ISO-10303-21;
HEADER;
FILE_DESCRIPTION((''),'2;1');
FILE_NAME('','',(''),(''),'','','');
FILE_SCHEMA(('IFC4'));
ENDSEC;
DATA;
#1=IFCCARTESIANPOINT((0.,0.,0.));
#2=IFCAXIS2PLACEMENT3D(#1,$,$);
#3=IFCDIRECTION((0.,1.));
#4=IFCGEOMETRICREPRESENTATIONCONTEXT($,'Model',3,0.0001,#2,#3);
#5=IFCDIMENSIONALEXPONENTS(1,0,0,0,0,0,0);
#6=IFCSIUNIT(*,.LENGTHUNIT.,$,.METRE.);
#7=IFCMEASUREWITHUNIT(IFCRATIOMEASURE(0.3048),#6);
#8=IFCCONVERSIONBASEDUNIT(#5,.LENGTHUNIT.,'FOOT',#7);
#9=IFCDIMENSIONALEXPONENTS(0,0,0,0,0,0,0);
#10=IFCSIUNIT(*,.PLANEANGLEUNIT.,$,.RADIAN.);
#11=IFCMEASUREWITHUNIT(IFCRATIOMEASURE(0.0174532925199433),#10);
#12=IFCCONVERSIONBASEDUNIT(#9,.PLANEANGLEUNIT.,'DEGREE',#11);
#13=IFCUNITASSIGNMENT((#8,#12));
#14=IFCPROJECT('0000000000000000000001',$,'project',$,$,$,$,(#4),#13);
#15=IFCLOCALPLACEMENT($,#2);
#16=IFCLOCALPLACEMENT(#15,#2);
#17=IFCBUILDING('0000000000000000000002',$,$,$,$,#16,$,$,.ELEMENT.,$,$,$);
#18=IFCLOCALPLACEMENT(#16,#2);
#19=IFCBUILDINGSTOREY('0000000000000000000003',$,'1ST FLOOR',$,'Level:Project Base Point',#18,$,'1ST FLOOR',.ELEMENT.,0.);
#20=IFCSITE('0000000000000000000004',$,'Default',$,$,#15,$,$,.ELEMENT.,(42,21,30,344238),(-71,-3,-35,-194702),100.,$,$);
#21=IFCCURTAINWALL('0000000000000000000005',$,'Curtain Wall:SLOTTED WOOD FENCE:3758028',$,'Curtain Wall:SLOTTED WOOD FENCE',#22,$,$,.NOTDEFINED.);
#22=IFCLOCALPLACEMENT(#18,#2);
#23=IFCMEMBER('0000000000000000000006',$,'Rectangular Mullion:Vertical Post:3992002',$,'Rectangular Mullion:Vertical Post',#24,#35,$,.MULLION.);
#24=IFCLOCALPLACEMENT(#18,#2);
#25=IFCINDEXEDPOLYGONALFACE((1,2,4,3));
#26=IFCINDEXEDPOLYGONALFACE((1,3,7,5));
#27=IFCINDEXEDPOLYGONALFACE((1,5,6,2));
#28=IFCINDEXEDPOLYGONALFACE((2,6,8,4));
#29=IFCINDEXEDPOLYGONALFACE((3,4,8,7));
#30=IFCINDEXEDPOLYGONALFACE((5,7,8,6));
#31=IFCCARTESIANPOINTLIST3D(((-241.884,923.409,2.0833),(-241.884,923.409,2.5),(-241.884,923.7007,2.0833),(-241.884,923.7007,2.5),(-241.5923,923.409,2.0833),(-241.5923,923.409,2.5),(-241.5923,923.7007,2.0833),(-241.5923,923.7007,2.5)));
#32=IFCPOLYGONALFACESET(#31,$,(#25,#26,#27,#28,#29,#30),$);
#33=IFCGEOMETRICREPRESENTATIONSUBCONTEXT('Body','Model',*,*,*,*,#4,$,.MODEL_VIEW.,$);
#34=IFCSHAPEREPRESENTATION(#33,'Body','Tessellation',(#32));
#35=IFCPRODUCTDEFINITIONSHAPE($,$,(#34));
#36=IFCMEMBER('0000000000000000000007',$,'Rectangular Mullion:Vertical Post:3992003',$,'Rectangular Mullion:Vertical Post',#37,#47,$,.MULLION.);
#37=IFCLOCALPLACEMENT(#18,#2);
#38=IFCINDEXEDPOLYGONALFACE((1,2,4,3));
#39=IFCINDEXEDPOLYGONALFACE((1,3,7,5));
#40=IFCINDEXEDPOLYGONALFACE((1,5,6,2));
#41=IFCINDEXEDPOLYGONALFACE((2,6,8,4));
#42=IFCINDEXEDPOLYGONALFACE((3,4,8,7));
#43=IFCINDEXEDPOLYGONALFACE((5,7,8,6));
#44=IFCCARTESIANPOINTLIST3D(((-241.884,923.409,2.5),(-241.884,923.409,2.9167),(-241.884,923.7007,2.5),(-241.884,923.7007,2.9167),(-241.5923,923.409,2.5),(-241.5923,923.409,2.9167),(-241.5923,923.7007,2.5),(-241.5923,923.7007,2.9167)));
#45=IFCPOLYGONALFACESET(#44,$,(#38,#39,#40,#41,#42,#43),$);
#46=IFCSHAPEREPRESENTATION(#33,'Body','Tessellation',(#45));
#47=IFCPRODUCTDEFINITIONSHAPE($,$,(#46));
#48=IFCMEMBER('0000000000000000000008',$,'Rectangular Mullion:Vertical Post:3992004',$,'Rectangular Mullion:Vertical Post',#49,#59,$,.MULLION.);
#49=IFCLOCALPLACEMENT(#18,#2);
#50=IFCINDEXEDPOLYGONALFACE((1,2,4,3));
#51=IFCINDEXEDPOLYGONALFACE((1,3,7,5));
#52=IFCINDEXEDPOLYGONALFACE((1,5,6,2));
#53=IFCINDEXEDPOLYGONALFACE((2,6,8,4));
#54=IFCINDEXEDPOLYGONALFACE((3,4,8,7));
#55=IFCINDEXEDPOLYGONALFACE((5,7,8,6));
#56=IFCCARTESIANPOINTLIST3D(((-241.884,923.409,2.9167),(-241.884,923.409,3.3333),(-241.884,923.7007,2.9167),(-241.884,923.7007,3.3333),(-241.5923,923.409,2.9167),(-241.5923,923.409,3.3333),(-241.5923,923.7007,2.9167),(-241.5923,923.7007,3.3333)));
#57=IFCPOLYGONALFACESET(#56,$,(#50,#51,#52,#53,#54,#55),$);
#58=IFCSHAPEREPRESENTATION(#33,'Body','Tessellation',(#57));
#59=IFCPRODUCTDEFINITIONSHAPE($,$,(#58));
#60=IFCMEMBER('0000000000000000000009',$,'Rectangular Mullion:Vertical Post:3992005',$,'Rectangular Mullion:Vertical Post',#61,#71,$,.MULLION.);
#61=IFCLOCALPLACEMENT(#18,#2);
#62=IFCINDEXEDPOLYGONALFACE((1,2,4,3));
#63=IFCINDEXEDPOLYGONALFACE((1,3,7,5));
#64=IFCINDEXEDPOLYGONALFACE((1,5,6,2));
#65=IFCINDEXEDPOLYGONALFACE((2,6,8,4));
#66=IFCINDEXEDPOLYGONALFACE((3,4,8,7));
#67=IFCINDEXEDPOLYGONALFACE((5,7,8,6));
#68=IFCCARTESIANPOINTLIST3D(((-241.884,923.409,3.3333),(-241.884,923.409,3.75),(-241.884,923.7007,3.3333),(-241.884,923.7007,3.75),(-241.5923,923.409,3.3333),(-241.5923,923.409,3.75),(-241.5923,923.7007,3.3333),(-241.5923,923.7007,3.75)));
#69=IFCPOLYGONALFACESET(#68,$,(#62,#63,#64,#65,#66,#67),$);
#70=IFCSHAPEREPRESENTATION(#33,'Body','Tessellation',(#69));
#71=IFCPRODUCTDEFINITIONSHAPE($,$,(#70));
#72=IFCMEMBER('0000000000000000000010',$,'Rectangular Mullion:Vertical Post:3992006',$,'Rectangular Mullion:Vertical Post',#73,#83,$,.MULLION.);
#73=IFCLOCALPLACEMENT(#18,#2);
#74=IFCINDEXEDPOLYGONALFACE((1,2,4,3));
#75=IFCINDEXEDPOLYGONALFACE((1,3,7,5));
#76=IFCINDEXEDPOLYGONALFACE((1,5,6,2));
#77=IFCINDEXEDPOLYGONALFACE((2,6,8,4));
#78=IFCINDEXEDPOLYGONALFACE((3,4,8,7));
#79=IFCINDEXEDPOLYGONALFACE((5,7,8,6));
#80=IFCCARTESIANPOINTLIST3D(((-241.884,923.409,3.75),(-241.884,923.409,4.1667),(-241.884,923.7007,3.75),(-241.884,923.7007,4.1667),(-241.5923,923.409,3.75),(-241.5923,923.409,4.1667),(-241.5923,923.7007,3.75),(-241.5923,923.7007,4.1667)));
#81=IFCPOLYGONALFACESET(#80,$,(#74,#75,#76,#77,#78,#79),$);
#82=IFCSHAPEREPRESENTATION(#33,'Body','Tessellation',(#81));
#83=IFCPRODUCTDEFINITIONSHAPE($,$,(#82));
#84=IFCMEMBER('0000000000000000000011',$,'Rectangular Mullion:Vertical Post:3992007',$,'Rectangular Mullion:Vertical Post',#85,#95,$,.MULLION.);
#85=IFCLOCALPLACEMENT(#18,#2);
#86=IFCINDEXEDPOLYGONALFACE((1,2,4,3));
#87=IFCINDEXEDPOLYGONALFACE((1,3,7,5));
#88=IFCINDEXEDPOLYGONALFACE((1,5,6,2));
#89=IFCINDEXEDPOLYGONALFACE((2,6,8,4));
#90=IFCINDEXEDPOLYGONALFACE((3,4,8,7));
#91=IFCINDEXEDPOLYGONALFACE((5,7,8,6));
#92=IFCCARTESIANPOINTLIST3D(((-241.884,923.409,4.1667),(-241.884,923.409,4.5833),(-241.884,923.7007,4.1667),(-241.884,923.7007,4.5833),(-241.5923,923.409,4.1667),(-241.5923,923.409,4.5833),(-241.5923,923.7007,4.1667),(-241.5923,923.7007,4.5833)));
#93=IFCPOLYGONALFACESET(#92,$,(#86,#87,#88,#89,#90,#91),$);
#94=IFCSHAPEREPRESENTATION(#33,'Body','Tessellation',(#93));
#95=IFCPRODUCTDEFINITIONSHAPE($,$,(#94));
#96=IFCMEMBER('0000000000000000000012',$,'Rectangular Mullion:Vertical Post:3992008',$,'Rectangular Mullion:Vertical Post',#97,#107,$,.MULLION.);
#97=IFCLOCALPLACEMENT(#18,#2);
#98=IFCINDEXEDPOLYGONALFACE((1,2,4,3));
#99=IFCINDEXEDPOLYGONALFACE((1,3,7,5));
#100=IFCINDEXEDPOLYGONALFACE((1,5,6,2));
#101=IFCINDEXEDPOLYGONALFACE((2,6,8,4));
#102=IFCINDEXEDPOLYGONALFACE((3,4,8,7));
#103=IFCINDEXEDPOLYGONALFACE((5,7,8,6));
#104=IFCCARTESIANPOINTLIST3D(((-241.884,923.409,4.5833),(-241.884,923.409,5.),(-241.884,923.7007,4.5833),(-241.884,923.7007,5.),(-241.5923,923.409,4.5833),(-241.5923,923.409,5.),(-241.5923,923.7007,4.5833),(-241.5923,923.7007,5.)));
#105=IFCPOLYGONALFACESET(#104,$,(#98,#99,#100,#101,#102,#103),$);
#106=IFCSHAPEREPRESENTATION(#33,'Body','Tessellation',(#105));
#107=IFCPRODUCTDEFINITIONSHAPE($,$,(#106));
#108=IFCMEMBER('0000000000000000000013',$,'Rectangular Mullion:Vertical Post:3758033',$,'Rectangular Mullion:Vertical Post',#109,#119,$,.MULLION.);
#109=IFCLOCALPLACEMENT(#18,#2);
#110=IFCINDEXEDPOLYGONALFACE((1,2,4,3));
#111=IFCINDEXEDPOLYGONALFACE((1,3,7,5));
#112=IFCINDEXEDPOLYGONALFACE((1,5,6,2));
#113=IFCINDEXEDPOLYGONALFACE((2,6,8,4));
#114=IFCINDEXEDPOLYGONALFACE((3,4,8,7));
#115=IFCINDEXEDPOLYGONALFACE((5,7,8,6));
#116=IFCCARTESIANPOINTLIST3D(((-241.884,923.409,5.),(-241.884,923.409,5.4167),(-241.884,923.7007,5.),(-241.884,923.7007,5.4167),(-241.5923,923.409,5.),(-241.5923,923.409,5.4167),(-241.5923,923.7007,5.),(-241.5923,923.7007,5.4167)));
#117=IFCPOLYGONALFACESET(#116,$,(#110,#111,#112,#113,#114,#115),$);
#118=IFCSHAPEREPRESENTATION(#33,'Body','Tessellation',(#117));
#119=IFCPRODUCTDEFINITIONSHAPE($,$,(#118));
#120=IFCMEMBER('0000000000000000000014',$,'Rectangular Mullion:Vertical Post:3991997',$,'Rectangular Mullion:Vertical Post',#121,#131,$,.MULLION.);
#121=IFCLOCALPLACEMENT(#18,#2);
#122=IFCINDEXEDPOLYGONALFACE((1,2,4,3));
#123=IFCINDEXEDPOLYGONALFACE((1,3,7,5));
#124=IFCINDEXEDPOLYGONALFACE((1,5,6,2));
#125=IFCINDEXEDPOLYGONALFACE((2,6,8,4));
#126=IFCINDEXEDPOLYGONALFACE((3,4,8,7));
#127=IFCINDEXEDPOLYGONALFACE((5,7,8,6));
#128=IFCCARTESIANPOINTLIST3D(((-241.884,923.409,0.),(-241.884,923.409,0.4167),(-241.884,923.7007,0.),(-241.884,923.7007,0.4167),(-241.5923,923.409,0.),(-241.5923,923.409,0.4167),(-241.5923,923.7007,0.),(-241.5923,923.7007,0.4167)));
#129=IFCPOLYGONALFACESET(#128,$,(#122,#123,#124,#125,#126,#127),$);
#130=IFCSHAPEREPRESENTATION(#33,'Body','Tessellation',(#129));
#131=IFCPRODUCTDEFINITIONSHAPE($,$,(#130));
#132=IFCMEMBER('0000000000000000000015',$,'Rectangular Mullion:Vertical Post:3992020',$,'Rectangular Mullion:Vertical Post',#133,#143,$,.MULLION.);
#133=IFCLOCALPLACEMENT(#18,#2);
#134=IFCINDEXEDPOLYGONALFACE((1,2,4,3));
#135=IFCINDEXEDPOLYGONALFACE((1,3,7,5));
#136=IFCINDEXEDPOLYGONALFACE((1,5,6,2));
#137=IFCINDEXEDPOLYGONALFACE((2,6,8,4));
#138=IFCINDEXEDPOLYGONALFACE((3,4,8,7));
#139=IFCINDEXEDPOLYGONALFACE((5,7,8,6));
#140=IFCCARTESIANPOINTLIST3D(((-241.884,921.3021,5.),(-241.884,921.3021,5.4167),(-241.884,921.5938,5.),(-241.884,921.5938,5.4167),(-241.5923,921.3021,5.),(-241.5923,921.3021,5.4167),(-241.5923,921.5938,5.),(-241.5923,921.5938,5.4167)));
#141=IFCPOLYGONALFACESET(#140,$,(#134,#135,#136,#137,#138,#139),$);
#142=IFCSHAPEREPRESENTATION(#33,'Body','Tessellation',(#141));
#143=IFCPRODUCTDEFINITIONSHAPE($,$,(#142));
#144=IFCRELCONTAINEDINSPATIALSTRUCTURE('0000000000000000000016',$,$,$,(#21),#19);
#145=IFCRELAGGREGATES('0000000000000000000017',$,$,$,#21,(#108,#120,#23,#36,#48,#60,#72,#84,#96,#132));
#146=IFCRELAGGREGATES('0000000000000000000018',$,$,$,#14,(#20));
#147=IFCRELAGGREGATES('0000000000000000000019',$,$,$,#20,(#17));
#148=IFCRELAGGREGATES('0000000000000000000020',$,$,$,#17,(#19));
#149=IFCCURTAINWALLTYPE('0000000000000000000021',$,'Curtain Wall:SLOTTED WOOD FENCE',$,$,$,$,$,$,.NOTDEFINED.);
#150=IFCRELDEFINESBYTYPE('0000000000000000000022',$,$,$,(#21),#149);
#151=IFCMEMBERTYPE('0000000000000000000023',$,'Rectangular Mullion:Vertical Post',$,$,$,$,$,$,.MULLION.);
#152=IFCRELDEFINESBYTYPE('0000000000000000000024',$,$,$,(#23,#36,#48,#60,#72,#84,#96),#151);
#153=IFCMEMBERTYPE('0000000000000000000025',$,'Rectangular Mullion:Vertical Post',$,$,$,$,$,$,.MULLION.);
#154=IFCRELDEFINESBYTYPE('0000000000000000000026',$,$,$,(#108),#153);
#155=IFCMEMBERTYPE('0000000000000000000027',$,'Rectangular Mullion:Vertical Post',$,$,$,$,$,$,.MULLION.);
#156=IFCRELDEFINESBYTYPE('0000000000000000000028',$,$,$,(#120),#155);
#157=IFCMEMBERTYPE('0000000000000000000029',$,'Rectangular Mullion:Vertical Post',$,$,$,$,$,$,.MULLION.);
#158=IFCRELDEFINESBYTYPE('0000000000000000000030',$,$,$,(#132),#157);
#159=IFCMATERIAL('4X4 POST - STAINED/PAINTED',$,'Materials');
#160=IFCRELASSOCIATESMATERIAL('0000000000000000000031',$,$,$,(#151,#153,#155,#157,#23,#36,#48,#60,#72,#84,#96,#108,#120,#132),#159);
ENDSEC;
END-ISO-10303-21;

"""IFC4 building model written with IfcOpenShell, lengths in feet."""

from ifc_helpers import new_model, entity, si_unit, converted_unit, direction, frame, origin, origin_2d_with_axis, place, context, subcontext, project, spatial, rectangle, extrude, source, transform, mapped, material, material_profile, profile_set, profile_usage, type_object, type_shapes, element, aggregate, save


model = new_model("IFC4")

# Units and contexts
model_context = context("Model", 3, precision=0.0001, world=origin(), true_north=direction((0.0, 1.0)))
body_context = subcontext(model_context, "Body", "Model", "MODEL_VIEW")
ifc_project = project(units=[converted_unit("LENGTHUNIT", "FOOT", entity("IfcRatioMeasure", 0.3048), si_unit("LENGTHUNIT", "METRE"), dimensions=[1, 0, 0, 0, 0, 0, 0]), converted_unit("PLANEANGLEUNIT", "DEGREE", entity("IfcRatioMeasure", 0.0174532925199433), si_unit("PLANEANGLEUNIT", "RADIAN"), dimensions=[0, 0, 0, 0, 0, 0, 0])], contexts=[model_context])

# Site, building, storey
site_placement = place(None, origin())
site = spatial("IfcSite", under=ifc_project, at=site_placement, Name="Default", CompositionType="ELEMENT", RefLatitude=(42, 21, 30, 344238), RefLongitude=(-71, -3, -35, -194702), RefElevation=100.0)
building_placement = place(site_placement, origin())
building = spatial("IfcBuilding", under=site, at=building_placement, CompositionType="ELEMENT")
storey_placement = place(building_placement, origin())
storey = spatial("IfcBuildingStorey", under=building, at=storey_placement, Name="1ST FLOOR", ObjectType="Level:Project Base Point", LongName="1ST FLOOR", CompositionType="ELEMENT", Elevation=0.0)

# Curtain wall, members
curtain_wall_type = type_object("IfcCurtainWallType", Name="Curtain Wall:SLOTTED WOOD FENCE", PredefinedType="NOTDEFINED")
curtain_wall_placement = place(storey_placement, origin())
curtain_wall = element("IfcCurtainWall", 1, at=curtain_wall_placement, inside=storey, type_object=curtain_wall_type, Name="Curtain Wall:SLOTTED WOOD FENCE:3758028", ObjectType="Curtain Wall:SLOTTED WOOD FENCE", PredefinedType="NOTDEFINED")
ifc_material = material(Name="4X4 POST - STAINED/PAINTED", Category="Materials")
ifc_material_profile = material_profile(ifc_material, rectangle(XDim=0.2917, YDim=0.2917, at=origin_2d_with_axis()), Name="Vertical Post")
ifc_profile_set = profile_set([ifc_material_profile], Name="Vertical Post")
member_type_1 = type_object("IfcMemberType", Name="Rectangular Mullion:Vertical Post", PredefinedType="MULLION", material=ifc_profile_set)
shared_shape_1 = source(origin(), body_context, "Body", "SweptSolid", [
    extrude(rectangle(XDim=0.2917, YDim=0.2917, at=origin_2d_with_axis()), frame((-0.1458, 0.2083, -0.4167), z_axis=(0.0, 0.0, 1.0), x_axis=(0.0, -1.0, 0.0)), (0.0, 0.0, 1.0), 0.4167),
])
type_shapes(member_type_1, [shared_shape_1])
ifc_profile_usage_1 = profile_usage(ifc_profile_set)
member_1_placement = place(storey_placement, frame((-241.5298, 923.7007, 2.5), z_axis=(0.0, 0.0, 1.0), x_axis=(0.0, 1.0, 0.0)))
member_1 = element("IfcMember", 2, at=member_1_placement, type_object=member_type_1, material=ifc_profile_usage_1, Name="Rectangular Mullion:Vertical Post:3992002", ObjectType="Rectangular Mullion:Vertical Post", PredefinedType="MULLION", context=body_context, shape_type="MappedRepresentation", body=[
    mapped(shared_shape_1, transform((0.0, 0.0, 0.0), scale=1.0)),
])
ifc_profile_usage_2 = profile_usage(ifc_profile_set)
member_2_placement = place(storey_placement, frame((-241.5298, 923.7007, 2.9167), z_axis=(0.0, 0.0, 1.0), x_axis=(0.0, 1.0, 0.0)))
member_2 = element("IfcMember", 3, at=member_2_placement, type_object=member_type_1, material=ifc_profile_usage_2, Name="Rectangular Mullion:Vertical Post:3992003", ObjectType="Rectangular Mullion:Vertical Post", PredefinedType="MULLION", context=body_context, shape_type="MappedRepresentation", body=[
    mapped(shared_shape_1, transform((0.0, 0.0, 0.0), scale=1.0)),
])
ifc_profile_usage_3 = profile_usage(ifc_profile_set)
member_3_placement = place(storey_placement, frame((-241.5298, 923.7007, 3.3333), z_axis=(0.0, 0.0, 1.0), x_axis=(0.0, 1.0, 0.0)))
member_3 = element("IfcMember", 4, at=member_3_placement, type_object=member_type_1, material=ifc_profile_usage_3, Name="Rectangular Mullion:Vertical Post:3992004", ObjectType="Rectangular Mullion:Vertical Post", PredefinedType="MULLION", context=body_context, shape_type="MappedRepresentation", body=[
    mapped(shared_shape_1, transform((0.0, 0.0, 0.0), scale=1.0)),
])
ifc_profile_usage_4 = profile_usage(ifc_profile_set)
member_4_placement = place(storey_placement, frame((-241.5298, 923.7007, 3.75), z_axis=(0.0, 0.0, 1.0), x_axis=(0.0, 1.0, 0.0)))
member_4 = element("IfcMember", 5, at=member_4_placement, type_object=member_type_1, material=ifc_profile_usage_4, Name="Rectangular Mullion:Vertical Post:3992005", ObjectType="Rectangular Mullion:Vertical Post", PredefinedType="MULLION", context=body_context, shape_type="MappedRepresentation", body=[
    mapped(shared_shape_1, transform((0.0, 0.0, 0.0), scale=1.0)),
])
ifc_profile_usage_5 = profile_usage(ifc_profile_set)
member_5_placement = place(storey_placement, frame((-241.5298, 923.7007, 4.1667), z_axis=(0.0, 0.0, 1.0), x_axis=(0.0, 1.0, 0.0)))
member_5 = element("IfcMember", 6, at=member_5_placement, type_object=member_type_1, material=ifc_profile_usage_5, Name="Rectangular Mullion:Vertical Post:3992006", ObjectType="Rectangular Mullion:Vertical Post", PredefinedType="MULLION", context=body_context, shape_type="MappedRepresentation", body=[
    mapped(shared_shape_1, transform((0.0, 0.0, 0.0), scale=1.0)),
])
ifc_profile_usage_6 = profile_usage(ifc_profile_set)
member_6_placement = place(storey_placement, frame((-241.5298, 923.7007, 4.5833), z_axis=(0.0, 0.0, 1.0), x_axis=(0.0, 1.0, 0.0)))
member_6 = element("IfcMember", 7, at=member_6_placement, type_object=member_type_1, material=ifc_profile_usage_6, Name="Rectangular Mullion:Vertical Post:3992007", ObjectType="Rectangular Mullion:Vertical Post", PredefinedType="MULLION", context=body_context, shape_type="MappedRepresentation", body=[
    mapped(shared_shape_1, transform((0.0, 0.0, 0.0), scale=1.0)),
])
ifc_profile_usage_7 = profile_usage(ifc_profile_set)
member_7_placement = place(storey_placement, frame((-241.5298, 923.7007, 5.0), z_axis=(0.0, 0.0, 1.0), x_axis=(0.0, 1.0, 0.0)))
member_7 = element("IfcMember", 8, at=member_7_placement, type_object=member_type_1, material=ifc_profile_usage_7, Name="Rectangular Mullion:Vertical Post:3992008", ObjectType="Rectangular Mullion:Vertical Post", PredefinedType="MULLION", context=body_context, shape_type="MappedRepresentation", body=[
    mapped(shared_shape_1, transform((0.0, 0.0, 0.0), scale=1.0)),
])
ifc_profile_usage_8 = profile_usage(ifc_profile_set)
member_type_2 = type_object("IfcMemberType", Name="Rectangular Mullion:Vertical Post", PredefinedType="MULLION", material=ifc_profile_set)
shared_shape_2 = source(origin(), body_context, "Body", "SweptSolid", [
    extrude(rectangle(XDim=0.2917, YDim=0.2917, at=origin_2d_with_axis()), frame((-0.1458, 0.2083, -0.4167), z_axis=(0.0, 0.0, 1.0), x_axis=(0.0, -1.0, 0.0)), (0.0, 0.0, 1.0), 0.4167),
])
type_shapes(member_type_2, [shared_shape_2])
placement = place(building_placement, frame((0.0, 0.0, 10.8021)))
member_8_placement = place(placement, frame((-241.5298, 923.7007, -5.3854), z_axis=(0.0, 0.0, 1.0), x_axis=(0.0, 1.0, 0.0)))
member_8 = element("IfcMember", 9, at=member_8_placement, type_object=member_type_2, material=ifc_profile_usage_8, Name="Rectangular Mullion:Vertical Post:3758033", ObjectType="Rectangular Mullion:Vertical Post", PredefinedType="MULLION", context=body_context, shape_type="MappedRepresentation", body=[
    mapped(shared_shape_2, transform((0.0, 0.0, 0.0), scale=1.0)),
])
ifc_profile_usage_9 = profile_usage(ifc_profile_set)
member_type_3 = type_object("IfcMemberType", Name="Rectangular Mullion:Vertical Post", PredefinedType="MULLION", material=ifc_profile_set)
shared_shape_3 = source(origin(), body_context, "Body", "SweptSolid", [
    extrude(rectangle(XDim=0.2917, YDim=0.2917, at=origin_2d_with_axis()), frame((-0.1458, 0.2083, -0.4167), z_axis=(0.0, 0.0, 1.0), x_axis=(0.0, -1.0, 0.0)), (0.0, 0.0, 1.0), 0.4167),
])
type_shapes(member_type_3, [shared_shape_3])
member_9_placement = place(storey_placement, frame((-241.5298, 923.7007, 0.4167), z_axis=(0.0, 0.0, 1.0), x_axis=(0.0, 1.0, 0.0)))
member_9 = element("IfcMember", 10, at=member_9_placement, type_object=member_type_3, material=ifc_profile_usage_9, Name="Rectangular Mullion:Vertical Post:3991997", ObjectType="Rectangular Mullion:Vertical Post", PredefinedType="MULLION", context=body_context, shape_type="MappedRepresentation", body=[
    mapped(shared_shape_3, transform((0.0, 0.0, 0.0), scale=1.0)),
])
ifc_profile_usage_10 = profile_usage(ifc_profile_set)
member_type_4 = type_object("IfcMemberType", Name="Rectangular Mullion:Vertical Post", PredefinedType="MULLION", material=ifc_profile_set)
shared_shape_4 = source(origin(), body_context, "Body", "SweptSolid", [
    extrude(rectangle(XDim=0.2917, YDim=0.2917, at=origin_2d_with_axis()), frame((0.0, 0.2083, -0.4167), z_axis=(0.0, 0.0, 1.0), x_axis=(0.0, -1.0, 0.0)), (0.0, 0.0, 1.0), 0.4167),
])
type_shapes(member_type_4, [shared_shape_4])
member_10_placement = place(storey_placement, frame((-241.5298, 921.448, 5.0), z_axis=(0.0, 0.0, -1.0), x_axis=(0.0, -1.0, 0.0)))
member_10 = element("IfcMember", 11, at=member_10_placement, type_object=member_type_4, material=ifc_profile_usage_10, Name="Rectangular Mullion:Vertical Post:3992020", ObjectType="Rectangular Mullion:Vertical Post", PredefinedType="MULLION", context=body_context, shape_type="MappedRepresentation", body=[
    mapped(shared_shape_4, transform((0.0, 0.0, 0.0), scale=1.0)),
])
aggregate(curtain_wall, [member_8, member_9, member_1, member_2, member_3, member_4, member_5, member_6, member_7, member_10])

save(model, "model.ifc")
